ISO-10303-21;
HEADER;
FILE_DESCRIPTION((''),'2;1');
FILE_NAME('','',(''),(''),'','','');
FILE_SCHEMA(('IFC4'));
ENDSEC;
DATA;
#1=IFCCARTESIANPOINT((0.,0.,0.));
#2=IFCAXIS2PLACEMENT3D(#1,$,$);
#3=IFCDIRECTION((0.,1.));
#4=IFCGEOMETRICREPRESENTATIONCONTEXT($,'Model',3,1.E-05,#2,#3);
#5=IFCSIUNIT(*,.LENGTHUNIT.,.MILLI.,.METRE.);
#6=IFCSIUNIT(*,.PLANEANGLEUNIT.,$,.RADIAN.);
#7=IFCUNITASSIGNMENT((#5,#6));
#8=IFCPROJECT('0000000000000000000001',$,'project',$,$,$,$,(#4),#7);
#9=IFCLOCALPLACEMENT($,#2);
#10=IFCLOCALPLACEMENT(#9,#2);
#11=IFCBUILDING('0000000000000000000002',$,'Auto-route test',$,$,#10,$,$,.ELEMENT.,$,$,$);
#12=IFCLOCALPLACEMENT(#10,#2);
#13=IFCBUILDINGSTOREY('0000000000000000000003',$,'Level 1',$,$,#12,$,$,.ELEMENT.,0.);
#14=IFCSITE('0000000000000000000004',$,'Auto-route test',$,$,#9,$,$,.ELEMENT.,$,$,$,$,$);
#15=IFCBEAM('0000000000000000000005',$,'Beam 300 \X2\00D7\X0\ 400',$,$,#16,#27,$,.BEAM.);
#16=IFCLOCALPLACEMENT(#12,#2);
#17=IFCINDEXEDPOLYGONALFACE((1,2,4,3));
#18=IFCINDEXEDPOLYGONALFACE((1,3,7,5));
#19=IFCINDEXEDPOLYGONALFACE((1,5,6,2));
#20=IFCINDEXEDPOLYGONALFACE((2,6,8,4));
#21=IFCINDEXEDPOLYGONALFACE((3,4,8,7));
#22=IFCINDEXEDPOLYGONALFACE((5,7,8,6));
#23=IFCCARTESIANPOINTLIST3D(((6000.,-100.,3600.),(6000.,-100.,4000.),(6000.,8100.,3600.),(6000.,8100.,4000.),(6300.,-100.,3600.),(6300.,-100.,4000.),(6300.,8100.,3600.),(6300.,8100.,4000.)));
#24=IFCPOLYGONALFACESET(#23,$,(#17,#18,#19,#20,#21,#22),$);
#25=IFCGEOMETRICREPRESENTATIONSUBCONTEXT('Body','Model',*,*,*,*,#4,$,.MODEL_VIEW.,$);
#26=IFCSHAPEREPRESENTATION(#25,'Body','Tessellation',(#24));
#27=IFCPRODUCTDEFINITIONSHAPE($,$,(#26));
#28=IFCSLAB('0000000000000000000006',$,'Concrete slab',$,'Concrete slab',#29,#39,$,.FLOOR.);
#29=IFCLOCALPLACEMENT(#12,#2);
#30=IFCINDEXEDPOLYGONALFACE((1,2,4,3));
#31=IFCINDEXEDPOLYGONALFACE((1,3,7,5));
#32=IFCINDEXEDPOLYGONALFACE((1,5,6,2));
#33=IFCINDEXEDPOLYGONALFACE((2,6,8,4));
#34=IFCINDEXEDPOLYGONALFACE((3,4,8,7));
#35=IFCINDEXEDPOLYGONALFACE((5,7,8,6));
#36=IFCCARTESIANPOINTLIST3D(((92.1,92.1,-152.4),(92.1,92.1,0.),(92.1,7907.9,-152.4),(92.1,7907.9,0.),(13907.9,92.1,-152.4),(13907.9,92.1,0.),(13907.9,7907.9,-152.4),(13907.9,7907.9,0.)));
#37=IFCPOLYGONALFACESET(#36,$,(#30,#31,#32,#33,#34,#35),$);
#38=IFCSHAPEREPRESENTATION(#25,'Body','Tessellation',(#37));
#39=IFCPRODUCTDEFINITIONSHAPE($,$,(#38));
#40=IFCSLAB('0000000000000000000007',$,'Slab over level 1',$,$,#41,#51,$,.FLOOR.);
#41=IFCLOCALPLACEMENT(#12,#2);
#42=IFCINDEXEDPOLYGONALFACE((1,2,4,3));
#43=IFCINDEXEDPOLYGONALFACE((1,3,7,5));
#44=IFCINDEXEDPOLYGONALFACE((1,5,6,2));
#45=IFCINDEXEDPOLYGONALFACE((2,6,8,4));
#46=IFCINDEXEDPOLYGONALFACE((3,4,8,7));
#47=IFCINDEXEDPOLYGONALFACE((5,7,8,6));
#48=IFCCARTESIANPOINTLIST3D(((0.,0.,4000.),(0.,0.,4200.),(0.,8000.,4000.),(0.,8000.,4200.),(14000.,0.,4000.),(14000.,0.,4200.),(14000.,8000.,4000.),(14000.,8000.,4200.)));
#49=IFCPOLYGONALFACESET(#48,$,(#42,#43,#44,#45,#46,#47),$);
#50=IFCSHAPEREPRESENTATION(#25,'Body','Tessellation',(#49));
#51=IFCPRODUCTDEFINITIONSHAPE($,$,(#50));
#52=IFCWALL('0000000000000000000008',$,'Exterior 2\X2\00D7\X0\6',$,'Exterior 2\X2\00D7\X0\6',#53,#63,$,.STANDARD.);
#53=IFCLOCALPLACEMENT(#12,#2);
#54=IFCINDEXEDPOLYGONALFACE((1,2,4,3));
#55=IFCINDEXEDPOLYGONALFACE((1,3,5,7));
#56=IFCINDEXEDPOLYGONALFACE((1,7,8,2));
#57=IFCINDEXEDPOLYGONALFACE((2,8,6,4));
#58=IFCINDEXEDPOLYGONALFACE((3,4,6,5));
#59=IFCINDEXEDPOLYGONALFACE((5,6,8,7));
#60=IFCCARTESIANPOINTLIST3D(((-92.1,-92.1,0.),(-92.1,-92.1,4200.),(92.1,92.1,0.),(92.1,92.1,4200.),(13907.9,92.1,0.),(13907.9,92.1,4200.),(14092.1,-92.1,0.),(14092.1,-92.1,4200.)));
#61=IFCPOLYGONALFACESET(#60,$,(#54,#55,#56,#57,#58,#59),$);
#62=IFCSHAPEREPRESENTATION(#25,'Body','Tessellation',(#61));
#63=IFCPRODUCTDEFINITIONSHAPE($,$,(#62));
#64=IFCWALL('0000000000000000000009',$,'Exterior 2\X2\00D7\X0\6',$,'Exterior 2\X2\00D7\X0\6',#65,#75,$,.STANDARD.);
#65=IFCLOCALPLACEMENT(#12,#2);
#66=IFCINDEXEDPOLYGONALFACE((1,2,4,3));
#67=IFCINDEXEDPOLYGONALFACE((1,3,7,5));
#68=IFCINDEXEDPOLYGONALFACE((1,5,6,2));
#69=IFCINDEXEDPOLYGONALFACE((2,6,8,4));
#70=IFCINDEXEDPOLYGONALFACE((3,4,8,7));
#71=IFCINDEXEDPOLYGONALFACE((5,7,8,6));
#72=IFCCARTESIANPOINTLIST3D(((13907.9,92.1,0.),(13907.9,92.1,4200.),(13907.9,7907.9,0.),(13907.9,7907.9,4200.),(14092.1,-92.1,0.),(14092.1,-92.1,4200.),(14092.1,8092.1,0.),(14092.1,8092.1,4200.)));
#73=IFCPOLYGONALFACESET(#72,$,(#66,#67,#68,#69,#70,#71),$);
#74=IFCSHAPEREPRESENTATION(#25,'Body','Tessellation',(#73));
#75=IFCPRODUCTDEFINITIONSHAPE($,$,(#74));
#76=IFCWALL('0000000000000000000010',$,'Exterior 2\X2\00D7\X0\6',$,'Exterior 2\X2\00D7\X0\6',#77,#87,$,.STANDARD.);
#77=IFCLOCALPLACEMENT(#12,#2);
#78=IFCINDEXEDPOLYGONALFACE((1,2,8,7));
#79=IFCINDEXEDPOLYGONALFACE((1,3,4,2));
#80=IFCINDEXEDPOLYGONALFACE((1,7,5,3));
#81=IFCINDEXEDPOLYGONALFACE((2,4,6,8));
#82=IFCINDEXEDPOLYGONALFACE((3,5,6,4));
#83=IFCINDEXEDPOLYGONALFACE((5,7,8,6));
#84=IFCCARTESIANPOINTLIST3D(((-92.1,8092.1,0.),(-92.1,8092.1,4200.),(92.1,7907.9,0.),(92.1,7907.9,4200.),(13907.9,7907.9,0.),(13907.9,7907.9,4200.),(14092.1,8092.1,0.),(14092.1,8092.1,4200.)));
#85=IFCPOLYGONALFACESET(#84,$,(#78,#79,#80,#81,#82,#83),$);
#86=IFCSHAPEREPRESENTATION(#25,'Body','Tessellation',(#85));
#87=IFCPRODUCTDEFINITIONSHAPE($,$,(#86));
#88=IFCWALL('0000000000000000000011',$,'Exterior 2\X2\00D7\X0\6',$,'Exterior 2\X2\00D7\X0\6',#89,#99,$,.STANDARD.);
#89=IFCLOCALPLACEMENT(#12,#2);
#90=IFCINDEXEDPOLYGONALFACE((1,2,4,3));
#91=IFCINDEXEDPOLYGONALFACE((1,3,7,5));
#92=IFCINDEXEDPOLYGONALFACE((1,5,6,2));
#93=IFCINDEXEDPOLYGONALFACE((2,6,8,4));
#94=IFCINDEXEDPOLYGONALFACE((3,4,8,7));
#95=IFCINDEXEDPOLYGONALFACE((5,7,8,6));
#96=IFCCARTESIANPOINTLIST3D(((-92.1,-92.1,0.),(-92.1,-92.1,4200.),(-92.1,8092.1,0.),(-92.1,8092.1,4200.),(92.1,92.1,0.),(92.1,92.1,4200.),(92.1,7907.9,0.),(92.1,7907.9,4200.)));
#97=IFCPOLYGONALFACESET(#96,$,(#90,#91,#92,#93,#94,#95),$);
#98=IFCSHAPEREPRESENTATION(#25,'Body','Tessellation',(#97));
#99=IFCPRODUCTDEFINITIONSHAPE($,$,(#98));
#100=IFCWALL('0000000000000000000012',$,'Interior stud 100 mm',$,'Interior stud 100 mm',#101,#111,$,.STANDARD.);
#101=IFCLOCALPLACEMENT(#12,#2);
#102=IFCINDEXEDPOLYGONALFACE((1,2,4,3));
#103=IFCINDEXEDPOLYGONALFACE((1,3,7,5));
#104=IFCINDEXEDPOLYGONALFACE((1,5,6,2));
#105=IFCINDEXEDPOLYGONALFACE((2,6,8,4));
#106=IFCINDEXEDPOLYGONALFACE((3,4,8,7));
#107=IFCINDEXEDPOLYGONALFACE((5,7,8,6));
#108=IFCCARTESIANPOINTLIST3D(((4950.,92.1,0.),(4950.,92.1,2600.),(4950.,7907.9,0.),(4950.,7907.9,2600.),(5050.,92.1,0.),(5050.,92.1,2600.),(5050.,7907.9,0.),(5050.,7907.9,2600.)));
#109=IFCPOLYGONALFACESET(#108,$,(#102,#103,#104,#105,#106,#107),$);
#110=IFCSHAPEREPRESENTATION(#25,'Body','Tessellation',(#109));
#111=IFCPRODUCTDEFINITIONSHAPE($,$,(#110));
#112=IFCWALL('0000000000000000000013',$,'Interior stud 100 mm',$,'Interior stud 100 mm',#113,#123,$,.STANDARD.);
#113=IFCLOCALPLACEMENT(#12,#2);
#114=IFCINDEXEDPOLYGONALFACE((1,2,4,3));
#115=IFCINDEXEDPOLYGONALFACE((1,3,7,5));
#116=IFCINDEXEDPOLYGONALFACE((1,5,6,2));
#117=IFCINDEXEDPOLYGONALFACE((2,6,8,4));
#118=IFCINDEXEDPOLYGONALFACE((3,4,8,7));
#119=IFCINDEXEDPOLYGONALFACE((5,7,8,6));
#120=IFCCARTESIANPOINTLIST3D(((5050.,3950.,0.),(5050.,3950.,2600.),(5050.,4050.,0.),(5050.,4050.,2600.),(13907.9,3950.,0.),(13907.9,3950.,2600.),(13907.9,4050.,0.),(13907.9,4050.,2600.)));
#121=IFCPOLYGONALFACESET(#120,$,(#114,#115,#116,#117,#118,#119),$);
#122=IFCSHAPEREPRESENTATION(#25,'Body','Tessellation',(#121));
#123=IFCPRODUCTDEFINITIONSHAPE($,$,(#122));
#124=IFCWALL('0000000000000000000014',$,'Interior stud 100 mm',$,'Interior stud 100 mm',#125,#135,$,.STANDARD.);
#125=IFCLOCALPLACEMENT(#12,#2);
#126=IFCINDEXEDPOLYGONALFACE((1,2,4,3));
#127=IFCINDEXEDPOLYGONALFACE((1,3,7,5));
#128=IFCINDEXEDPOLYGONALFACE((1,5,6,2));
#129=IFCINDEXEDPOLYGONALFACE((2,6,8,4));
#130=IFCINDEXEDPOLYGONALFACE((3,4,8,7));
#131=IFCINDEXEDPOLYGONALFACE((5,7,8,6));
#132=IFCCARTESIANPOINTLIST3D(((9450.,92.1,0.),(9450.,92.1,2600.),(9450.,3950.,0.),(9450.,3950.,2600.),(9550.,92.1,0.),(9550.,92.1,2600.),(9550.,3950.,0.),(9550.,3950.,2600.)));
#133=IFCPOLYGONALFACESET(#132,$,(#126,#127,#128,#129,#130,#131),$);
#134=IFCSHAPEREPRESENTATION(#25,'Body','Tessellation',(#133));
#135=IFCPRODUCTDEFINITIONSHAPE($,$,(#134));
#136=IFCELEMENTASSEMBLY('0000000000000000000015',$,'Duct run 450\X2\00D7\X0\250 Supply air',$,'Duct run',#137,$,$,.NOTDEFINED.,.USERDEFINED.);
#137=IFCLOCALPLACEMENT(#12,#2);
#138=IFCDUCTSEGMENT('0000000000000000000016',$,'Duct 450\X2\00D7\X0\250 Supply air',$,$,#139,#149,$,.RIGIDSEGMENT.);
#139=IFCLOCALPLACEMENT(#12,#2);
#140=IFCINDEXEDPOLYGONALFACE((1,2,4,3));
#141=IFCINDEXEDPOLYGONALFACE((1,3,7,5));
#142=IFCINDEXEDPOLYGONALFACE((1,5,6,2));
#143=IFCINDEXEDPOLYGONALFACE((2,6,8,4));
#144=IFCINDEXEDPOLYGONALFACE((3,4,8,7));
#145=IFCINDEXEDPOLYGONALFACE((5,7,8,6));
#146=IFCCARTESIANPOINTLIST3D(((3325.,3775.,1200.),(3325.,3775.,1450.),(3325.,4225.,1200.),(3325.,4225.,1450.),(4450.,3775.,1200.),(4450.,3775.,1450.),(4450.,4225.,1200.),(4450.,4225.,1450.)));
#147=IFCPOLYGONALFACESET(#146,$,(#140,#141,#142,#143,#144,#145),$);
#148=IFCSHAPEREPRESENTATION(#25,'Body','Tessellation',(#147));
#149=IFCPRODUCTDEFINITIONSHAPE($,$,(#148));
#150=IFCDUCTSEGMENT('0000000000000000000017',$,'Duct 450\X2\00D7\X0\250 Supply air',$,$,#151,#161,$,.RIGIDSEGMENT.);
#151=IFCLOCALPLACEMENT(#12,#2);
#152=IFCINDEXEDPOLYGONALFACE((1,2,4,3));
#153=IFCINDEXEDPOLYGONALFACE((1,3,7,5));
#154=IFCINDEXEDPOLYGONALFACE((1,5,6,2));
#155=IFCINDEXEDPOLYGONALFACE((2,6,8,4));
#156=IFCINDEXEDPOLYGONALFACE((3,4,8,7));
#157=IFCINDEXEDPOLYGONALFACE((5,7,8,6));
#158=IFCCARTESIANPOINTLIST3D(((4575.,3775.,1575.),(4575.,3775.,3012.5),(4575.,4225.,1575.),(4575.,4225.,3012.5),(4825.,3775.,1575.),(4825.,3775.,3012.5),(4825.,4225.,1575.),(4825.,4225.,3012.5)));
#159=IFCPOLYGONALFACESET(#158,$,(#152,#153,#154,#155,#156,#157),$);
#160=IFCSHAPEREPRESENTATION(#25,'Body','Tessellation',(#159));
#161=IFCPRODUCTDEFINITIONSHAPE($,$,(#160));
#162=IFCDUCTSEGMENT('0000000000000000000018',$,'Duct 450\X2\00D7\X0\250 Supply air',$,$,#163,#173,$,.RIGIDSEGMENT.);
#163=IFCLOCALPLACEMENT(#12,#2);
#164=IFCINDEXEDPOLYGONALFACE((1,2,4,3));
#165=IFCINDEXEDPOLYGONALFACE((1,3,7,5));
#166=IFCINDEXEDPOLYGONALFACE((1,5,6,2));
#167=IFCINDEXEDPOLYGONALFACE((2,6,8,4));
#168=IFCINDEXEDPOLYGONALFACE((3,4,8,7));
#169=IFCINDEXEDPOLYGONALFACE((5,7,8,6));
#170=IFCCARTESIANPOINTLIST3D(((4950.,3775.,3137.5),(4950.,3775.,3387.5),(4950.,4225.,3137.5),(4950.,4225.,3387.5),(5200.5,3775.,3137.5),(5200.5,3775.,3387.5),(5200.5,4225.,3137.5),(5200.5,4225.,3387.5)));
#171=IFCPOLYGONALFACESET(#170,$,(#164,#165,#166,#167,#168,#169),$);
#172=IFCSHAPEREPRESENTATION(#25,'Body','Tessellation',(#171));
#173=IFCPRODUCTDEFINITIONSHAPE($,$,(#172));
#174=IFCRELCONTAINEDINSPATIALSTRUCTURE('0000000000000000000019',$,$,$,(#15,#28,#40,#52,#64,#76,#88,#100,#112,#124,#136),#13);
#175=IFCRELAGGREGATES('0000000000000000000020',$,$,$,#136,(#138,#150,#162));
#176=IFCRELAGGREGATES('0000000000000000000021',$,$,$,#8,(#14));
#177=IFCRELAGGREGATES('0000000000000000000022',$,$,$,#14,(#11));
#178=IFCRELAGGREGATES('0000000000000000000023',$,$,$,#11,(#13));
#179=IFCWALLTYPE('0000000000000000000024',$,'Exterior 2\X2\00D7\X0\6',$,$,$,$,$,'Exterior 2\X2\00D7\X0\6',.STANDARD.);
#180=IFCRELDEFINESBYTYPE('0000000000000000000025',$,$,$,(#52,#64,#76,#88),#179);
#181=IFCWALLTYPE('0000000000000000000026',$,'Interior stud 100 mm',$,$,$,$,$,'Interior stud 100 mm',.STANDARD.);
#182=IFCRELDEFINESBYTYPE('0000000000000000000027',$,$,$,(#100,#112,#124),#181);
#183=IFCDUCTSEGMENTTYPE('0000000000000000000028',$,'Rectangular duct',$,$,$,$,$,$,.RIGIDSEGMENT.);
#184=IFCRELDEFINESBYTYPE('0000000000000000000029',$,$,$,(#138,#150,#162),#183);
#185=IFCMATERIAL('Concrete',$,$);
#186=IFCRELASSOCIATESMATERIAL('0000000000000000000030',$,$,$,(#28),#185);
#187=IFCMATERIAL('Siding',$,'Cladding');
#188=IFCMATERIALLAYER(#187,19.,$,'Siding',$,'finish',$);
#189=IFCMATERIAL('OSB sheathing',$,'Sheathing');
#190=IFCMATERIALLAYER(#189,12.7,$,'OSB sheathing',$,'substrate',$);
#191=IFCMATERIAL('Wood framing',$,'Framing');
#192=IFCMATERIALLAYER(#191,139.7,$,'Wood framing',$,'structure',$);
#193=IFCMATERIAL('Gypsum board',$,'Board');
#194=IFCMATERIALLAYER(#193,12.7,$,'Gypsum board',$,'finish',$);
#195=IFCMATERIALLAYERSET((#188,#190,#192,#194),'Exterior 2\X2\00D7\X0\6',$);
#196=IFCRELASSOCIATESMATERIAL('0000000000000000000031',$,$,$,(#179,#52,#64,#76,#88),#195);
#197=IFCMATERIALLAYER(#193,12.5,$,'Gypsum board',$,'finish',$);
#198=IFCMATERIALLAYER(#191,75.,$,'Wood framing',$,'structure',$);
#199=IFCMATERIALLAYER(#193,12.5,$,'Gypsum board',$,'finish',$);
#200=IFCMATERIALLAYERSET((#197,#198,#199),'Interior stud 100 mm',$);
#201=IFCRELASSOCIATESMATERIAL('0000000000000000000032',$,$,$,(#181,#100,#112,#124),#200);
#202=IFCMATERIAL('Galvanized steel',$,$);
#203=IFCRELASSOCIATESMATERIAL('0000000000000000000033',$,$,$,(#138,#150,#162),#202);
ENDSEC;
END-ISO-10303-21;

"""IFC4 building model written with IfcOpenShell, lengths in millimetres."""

from ifc_helpers import new_model, si_unit, direction, frame, origin, origin_with_axes, origin_2d, place, context, subcontext, project, spatial, polyline, rectangle, outline, extrude, material, layer, layer_set, layer_usage, type_object, element, aggregate, save


model = new_model("IFC4")

# Units and contexts
model_context = context("Model", 3, precision=1e-05, world=origin(), true_north=direction((0.0, 1.0)))
body_context = subcontext(model_context, "Body", "Model", "MODEL_VIEW")
ifc_project = project(units=[si_unit("LENGTHUNIT", "METRE", prefix="MILLI"), si_unit("PLANEANGLEUNIT", "RADIAN")], contexts=[model_context])

# Site, building, storey
site_placement = place(None, origin())
site = spatial("IfcSite", under=ifc_project, at=site_placement, Name="Auto-route test", CompositionType="ELEMENT")
building_placement = place(site_placement, origin())
building = spatial("IfcBuilding", under=site, at=building_placement, Name="Auto-route test", CompositionType="ELEMENT")
storey_placement = place(building_placement, origin())
storey = spatial("IfcBuildingStorey", under=building, at=storey_placement, Name="Level 1", CompositionType="ELEMENT", Elevation=0.0)

# Beam
beam_placement = place(storey_placement, origin_with_axes())
element("IfcBeam", 1, at=beam_placement, inside=storey, Name="Beam 300 × 400", PredefinedType="BEAM", context=body_context, shape_type="SweptSolid", body=[
    extrude(outline(polyline([(6000.0, -100.0), (6300.0, -100.0), (6300.0, 8100.0), (6000.0, 8100.0), (6000.0, -100.0)])), frame((0.0, 0.0, 3600.0)), (0.0, 0.0, 1.0), 400.0),
])

# Slabs
ifc_material_1 = material(Name="Concrete")
slab_1_placement = place(storey_placement, origin_with_axes())
element("IfcSlab", 2, at=slab_1_placement, inside=storey, material=ifc_material_1, Name="Concrete slab", ObjectType="Concrete slab", PredefinedType="FLOOR", context=body_context, shape_type="SweptSolid", body=[
    extrude(outline(polyline([(92.1, 92.1), (13907.9, 92.1), (13907.9, 7907.9), (92.1, 7907.9), (92.1, 92.1)])), frame((0.0, 0.0, -152.4)), (0.0, 0.0, 1.0), 152.4),
])
slab_2_placement = place(storey_placement, origin_with_axes())
element("IfcSlab", 3, at=slab_2_placement, inside=storey, Name="Slab over level 1", PredefinedType="FLOOR", context=body_context, shape_type="SweptSolid", body=[
    extrude(outline(polyline([(0.0, 0.0), (14000.0, 0.0), (14000.0, 8000.0), (0.0, 8000.0), (0.0, 0.0)])), frame((0.0, 0.0, 4000.0)), (0.0, 0.0, 1.0), 200.0),
])

# Walls
ifc_material_2 = material(Name="Siding", Category="Cladding")
ifc_layer_1 = layer(ifc_material_2, 19.0, Name="Siding", Category="finish")
ifc_material_3 = material(Name="OSB sheathing", Category="Sheathing")
ifc_layer_2 = layer(ifc_material_3, 12.7, Name="OSB sheathing", Category="substrate")
ifc_material_4 = material(Name="Wood framing", Category="Framing")
ifc_layer_3 = layer(ifc_material_4, 139.7, Name="Wood framing", Category="structure")
ifc_material_5 = material(Name="Gypsum board", Category="Board")
ifc_layer_4 = layer(ifc_material_5, 12.7, Name="Gypsum board", Category="finish")
ifc_layer_set_1 = layer_set([ifc_layer_1, ifc_layer_2, ifc_layer_3, ifc_layer_4], Name="Exterior 2×6")
ifc_layer_usage_1 = layer_usage(ifc_layer_set_1, "AXIS2", "NEGATIVE", 92.1)
wall_type_1 = type_object("IfcWallType", Name="Exterior 2×6", ElementType="Exterior 2×6", PredefinedType="STANDARD", material=ifc_layer_set_1)
wall_1_placement = place(storey_placement, origin_with_axes())
element("IfcWall", 4, at=wall_1_placement, inside=storey, type_object=wall_type_1, material=ifc_layer_usage_1, Name="Exterior 2×6", ObjectType="Exterior 2×6", PredefinedType="STANDARD", context=body_context, shape_type="SweptSolid", body=[
    extrude(outline(polyline([(-92.1, -92.1), (14092.1, -92.1), (13907.9, 92.1), (92.1, 92.1), (-92.1, -92.1)])), origin(), (0.0, 0.0, 1.0), 4200.0),
])
ifc_layer_usage_2 = layer_usage(ifc_layer_set_1, "AXIS2", "NEGATIVE", 92.1)
wall_2_placement = place(storey_placement, frame((14000.0, 0.0, 0.0), z_axis=(0.0, 0.0, 1.0), x_axis=(0.0, 1.0, 0.0)))
element("IfcWall", 5, at=wall_2_placement, inside=storey, type_object=wall_type_1, material=ifc_layer_usage_2, Name="Exterior 2×6", ObjectType="Exterior 2×6", PredefinedType="STANDARD", context=body_context, shape_type="SweptSolid", body=[
    extrude(outline(polyline([(-92.1, -92.1), (8092.1, -92.1), (7907.9, 92.1), (92.1, 92.1), (-92.1, -92.1)])), origin(), (0.0, 0.0, 1.0), 4200.0),
])
ifc_layer_usage_3 = layer_usage(ifc_layer_set_1, "AXIS2", "NEGATIVE", 92.1)
wall_3_placement = place(storey_placement, frame((14000.0, 8000.0, 0.0), z_axis=(0.0, 0.0, 1.0), x_axis=(-1.0, 0.0, 0.0)))
element("IfcWall", 6, at=wall_3_placement, inside=storey, type_object=wall_type_1, material=ifc_layer_usage_3, Name="Exterior 2×6", ObjectType="Exterior 2×6", PredefinedType="STANDARD", context=body_context, shape_type="SweptSolid", body=[
    extrude(outline(polyline([(-92.1, -92.1), (14092.1, -92.1), (13907.9, 92.1), (92.1, 92.1), (-92.1, -92.1)])), origin(), (0.0, 0.0, 1.0), 4200.0),
])
ifc_layer_usage_4 = layer_usage(ifc_layer_set_1, "AXIS2", "NEGATIVE", 92.1)
wall_4_placement = place(storey_placement, frame((0.0, 8000.0, 0.0), z_axis=(0.0, 0.0, 1.0), x_axis=(0.0, -1.0, 0.0)))
element("IfcWall", 7, at=wall_4_placement, inside=storey, type_object=wall_type_1, material=ifc_layer_usage_4, Name="Exterior 2×6", ObjectType="Exterior 2×6", PredefinedType="STANDARD", context=body_context, shape_type="SweptSolid", body=[
    extrude(outline(polyline([(-92.1, -92.1), (8092.1, -92.1), (7907.9, 92.1), (92.1, 92.1), (-92.1, -92.1)])), origin(), (0.0, 0.0, 1.0), 4200.0),
])
ifc_layer_5 = layer(ifc_material_5, 12.5, Name="Gypsum board", Category="finish")
ifc_layer_6 = layer(ifc_material_4, 75.0, Name="Wood framing", Category="structure")
ifc_layer_7 = layer(ifc_material_5, 12.5, Name="Gypsum board", Category="finish")
ifc_layer_set_2 = layer_set([ifc_layer_5, ifc_layer_6, ifc_layer_7], Name="Interior stud 100 mm")
ifc_layer_usage_5 = layer_usage(ifc_layer_set_2, "AXIS2", "NEGATIVE", 50.0)
wall_type_2 = type_object("IfcWallType", Name="Interior stud 100 mm", ElementType="Interior stud 100 mm", PredefinedType="STANDARD", material=ifc_layer_set_2)
wall_5_placement = place(storey_placement, frame((5000.0, 0.0, 0.0), z_axis=(0.0, 0.0, 1.0), x_axis=(0.0, 1.0, 0.0)))
element("IfcWall", 8, at=wall_5_placement, inside=storey, type_object=wall_type_2, material=ifc_layer_usage_5, Name="Interior stud 100 mm", ObjectType="Interior stud 100 mm", PredefinedType="STANDARD", context=body_context, shape_type="SweptSolid", body=[
    extrude(outline(polyline([(92.1, -50.0), (7907.9, -50.0), (7907.9, 50.0), (92.1, 50.0), (92.1, -50.0)])), origin(), (0.0, 0.0, 1.0), 2600.0),
])
ifc_layer_usage_6 = layer_usage(ifc_layer_set_2, "AXIS2", "NEGATIVE", 50.0)
wall_6_placement = place(storey_placement, frame((5000.0, 4000.0, 0.0), z_axis=(0.0, 0.0, 1.0), x_axis=(1.0, 0.0, 0.0)))
element("IfcWall", 9, at=wall_6_placement, inside=storey, type_object=wall_type_2, material=ifc_layer_usage_6, Name="Interior stud 100 mm", ObjectType="Interior stud 100 mm", PredefinedType="STANDARD", context=body_context, shape_type="SweptSolid", body=[
    extrude(outline(polyline([(50.0, -50.0), (8907.9, -50.0), (8907.9, 50.0), (50.0, 50.0), (50.0, -50.0)])), origin(), (0.0, 0.0, 1.0), 2600.0),
])
ifc_layer_usage_7 = layer_usage(ifc_layer_set_2, "AXIS2", "NEGATIVE", 50.0)
wall_7_placement = place(storey_placement, frame((9500.0, 0.0, 0.0), z_axis=(0.0, 0.0, 1.0), x_axis=(0.0, 1.0, 0.0)))
element("IfcWall", 10, at=wall_7_placement, inside=storey, type_object=wall_type_2, material=ifc_layer_usage_7, Name="Interior stud 100 mm", ObjectType="Interior stud 100 mm", PredefinedType="STANDARD", context=body_context, shape_type="SweptSolid", body=[
    extrude(outline(polyline([(92.1, -50.0), (3950.0, -50.0), (3950.0, 50.0), (92.1, 50.0), (92.1, -50.0)])), origin(), (0.0, 0.0, 1.0), 2600.0),
])

# Element assembly, duct segments
assembly_1_placement = place(storey_placement, origin_with_axes())
assembly_1 = element("IfcElementAssembly", 11, at=assembly_1_placement, inside=storey, Name="Duct run 450×250 Supply air", ObjectType="Duct run", AssemblyPlace="NOTDEFINED", PredefinedType="USERDEFINED")
ifc_material_6 = material(Name="Galvanized steel")
duct_segment_type_1 = type_object("IfcDuctSegmentType", Name="Rectangular duct", PredefinedType="RIGIDSEGMENT")
duct_segment_1_placement = place(storey_placement, origin_with_axes())
duct_segment_1 = element("IfcDuctSegment", 12, at=duct_segment_1_placement, type_object=duct_segment_type_1, material=ifc_material_6, Name="Duct 450×250 Supply air", PredefinedType="RIGIDSEGMENT", context=body_context, shape_type="SweptSolid", body=[
    extrude(rectangle(XDim=450.0, YDim=250.0, at=origin_2d()), frame((3325.0, 4000.0, 1325.0), z_axis=(1.0, 0.0, 0.0), x_axis=(0.0, 1.0, 0.0)), (0.0, 0.0, 1.0), 1125.0),
])
duct_segment_2_placement = place(storey_placement, origin_with_axes())
duct_segment_2 = element("IfcDuctSegment", 13, at=duct_segment_2_placement, type_object=duct_segment_type_1, material=ifc_material_6, Name="Duct 450×250 Supply air", PredefinedType="RIGIDSEGMENT", context=body_context, shape_type="SweptSolid", body=[
    extrude(rectangle(XDim=450.0, YDim=250.0, at=origin_2d()), frame((4700.0, 4000.0, 1575.0), z_axis=(0.0, 0.0, 1.0), x_axis=(0.0, 1.0, 0.0)), (0.0, 0.0, 1.0), 1437.5),
])
duct_segment_3_placement = place(storey_placement, origin_with_axes())
duct_segment_3 = element("IfcDuctSegment", 14, at=duct_segment_3_placement, type_object=duct_segment_type_1, material=ifc_material_6, Name="Duct 450×250 Supply air", PredefinedType="RIGIDSEGMENT", context=body_context, shape_type="SweptSolid", body=[
    extrude(rectangle(XDim=450.0, YDim=250.0, at=origin_2d()), frame((4950.0, 4000.0, 3262.5), z_axis=(1.0, 0.0, 0.0), x_axis=(0.0, 1.0, 0.0)), (0.0, 0.0, 1.0), 250.5),
])

aggregate(assembly_1, [duct_segment_1, duct_segment_2, duct_segment_3])

save(model, "model.ifc")
